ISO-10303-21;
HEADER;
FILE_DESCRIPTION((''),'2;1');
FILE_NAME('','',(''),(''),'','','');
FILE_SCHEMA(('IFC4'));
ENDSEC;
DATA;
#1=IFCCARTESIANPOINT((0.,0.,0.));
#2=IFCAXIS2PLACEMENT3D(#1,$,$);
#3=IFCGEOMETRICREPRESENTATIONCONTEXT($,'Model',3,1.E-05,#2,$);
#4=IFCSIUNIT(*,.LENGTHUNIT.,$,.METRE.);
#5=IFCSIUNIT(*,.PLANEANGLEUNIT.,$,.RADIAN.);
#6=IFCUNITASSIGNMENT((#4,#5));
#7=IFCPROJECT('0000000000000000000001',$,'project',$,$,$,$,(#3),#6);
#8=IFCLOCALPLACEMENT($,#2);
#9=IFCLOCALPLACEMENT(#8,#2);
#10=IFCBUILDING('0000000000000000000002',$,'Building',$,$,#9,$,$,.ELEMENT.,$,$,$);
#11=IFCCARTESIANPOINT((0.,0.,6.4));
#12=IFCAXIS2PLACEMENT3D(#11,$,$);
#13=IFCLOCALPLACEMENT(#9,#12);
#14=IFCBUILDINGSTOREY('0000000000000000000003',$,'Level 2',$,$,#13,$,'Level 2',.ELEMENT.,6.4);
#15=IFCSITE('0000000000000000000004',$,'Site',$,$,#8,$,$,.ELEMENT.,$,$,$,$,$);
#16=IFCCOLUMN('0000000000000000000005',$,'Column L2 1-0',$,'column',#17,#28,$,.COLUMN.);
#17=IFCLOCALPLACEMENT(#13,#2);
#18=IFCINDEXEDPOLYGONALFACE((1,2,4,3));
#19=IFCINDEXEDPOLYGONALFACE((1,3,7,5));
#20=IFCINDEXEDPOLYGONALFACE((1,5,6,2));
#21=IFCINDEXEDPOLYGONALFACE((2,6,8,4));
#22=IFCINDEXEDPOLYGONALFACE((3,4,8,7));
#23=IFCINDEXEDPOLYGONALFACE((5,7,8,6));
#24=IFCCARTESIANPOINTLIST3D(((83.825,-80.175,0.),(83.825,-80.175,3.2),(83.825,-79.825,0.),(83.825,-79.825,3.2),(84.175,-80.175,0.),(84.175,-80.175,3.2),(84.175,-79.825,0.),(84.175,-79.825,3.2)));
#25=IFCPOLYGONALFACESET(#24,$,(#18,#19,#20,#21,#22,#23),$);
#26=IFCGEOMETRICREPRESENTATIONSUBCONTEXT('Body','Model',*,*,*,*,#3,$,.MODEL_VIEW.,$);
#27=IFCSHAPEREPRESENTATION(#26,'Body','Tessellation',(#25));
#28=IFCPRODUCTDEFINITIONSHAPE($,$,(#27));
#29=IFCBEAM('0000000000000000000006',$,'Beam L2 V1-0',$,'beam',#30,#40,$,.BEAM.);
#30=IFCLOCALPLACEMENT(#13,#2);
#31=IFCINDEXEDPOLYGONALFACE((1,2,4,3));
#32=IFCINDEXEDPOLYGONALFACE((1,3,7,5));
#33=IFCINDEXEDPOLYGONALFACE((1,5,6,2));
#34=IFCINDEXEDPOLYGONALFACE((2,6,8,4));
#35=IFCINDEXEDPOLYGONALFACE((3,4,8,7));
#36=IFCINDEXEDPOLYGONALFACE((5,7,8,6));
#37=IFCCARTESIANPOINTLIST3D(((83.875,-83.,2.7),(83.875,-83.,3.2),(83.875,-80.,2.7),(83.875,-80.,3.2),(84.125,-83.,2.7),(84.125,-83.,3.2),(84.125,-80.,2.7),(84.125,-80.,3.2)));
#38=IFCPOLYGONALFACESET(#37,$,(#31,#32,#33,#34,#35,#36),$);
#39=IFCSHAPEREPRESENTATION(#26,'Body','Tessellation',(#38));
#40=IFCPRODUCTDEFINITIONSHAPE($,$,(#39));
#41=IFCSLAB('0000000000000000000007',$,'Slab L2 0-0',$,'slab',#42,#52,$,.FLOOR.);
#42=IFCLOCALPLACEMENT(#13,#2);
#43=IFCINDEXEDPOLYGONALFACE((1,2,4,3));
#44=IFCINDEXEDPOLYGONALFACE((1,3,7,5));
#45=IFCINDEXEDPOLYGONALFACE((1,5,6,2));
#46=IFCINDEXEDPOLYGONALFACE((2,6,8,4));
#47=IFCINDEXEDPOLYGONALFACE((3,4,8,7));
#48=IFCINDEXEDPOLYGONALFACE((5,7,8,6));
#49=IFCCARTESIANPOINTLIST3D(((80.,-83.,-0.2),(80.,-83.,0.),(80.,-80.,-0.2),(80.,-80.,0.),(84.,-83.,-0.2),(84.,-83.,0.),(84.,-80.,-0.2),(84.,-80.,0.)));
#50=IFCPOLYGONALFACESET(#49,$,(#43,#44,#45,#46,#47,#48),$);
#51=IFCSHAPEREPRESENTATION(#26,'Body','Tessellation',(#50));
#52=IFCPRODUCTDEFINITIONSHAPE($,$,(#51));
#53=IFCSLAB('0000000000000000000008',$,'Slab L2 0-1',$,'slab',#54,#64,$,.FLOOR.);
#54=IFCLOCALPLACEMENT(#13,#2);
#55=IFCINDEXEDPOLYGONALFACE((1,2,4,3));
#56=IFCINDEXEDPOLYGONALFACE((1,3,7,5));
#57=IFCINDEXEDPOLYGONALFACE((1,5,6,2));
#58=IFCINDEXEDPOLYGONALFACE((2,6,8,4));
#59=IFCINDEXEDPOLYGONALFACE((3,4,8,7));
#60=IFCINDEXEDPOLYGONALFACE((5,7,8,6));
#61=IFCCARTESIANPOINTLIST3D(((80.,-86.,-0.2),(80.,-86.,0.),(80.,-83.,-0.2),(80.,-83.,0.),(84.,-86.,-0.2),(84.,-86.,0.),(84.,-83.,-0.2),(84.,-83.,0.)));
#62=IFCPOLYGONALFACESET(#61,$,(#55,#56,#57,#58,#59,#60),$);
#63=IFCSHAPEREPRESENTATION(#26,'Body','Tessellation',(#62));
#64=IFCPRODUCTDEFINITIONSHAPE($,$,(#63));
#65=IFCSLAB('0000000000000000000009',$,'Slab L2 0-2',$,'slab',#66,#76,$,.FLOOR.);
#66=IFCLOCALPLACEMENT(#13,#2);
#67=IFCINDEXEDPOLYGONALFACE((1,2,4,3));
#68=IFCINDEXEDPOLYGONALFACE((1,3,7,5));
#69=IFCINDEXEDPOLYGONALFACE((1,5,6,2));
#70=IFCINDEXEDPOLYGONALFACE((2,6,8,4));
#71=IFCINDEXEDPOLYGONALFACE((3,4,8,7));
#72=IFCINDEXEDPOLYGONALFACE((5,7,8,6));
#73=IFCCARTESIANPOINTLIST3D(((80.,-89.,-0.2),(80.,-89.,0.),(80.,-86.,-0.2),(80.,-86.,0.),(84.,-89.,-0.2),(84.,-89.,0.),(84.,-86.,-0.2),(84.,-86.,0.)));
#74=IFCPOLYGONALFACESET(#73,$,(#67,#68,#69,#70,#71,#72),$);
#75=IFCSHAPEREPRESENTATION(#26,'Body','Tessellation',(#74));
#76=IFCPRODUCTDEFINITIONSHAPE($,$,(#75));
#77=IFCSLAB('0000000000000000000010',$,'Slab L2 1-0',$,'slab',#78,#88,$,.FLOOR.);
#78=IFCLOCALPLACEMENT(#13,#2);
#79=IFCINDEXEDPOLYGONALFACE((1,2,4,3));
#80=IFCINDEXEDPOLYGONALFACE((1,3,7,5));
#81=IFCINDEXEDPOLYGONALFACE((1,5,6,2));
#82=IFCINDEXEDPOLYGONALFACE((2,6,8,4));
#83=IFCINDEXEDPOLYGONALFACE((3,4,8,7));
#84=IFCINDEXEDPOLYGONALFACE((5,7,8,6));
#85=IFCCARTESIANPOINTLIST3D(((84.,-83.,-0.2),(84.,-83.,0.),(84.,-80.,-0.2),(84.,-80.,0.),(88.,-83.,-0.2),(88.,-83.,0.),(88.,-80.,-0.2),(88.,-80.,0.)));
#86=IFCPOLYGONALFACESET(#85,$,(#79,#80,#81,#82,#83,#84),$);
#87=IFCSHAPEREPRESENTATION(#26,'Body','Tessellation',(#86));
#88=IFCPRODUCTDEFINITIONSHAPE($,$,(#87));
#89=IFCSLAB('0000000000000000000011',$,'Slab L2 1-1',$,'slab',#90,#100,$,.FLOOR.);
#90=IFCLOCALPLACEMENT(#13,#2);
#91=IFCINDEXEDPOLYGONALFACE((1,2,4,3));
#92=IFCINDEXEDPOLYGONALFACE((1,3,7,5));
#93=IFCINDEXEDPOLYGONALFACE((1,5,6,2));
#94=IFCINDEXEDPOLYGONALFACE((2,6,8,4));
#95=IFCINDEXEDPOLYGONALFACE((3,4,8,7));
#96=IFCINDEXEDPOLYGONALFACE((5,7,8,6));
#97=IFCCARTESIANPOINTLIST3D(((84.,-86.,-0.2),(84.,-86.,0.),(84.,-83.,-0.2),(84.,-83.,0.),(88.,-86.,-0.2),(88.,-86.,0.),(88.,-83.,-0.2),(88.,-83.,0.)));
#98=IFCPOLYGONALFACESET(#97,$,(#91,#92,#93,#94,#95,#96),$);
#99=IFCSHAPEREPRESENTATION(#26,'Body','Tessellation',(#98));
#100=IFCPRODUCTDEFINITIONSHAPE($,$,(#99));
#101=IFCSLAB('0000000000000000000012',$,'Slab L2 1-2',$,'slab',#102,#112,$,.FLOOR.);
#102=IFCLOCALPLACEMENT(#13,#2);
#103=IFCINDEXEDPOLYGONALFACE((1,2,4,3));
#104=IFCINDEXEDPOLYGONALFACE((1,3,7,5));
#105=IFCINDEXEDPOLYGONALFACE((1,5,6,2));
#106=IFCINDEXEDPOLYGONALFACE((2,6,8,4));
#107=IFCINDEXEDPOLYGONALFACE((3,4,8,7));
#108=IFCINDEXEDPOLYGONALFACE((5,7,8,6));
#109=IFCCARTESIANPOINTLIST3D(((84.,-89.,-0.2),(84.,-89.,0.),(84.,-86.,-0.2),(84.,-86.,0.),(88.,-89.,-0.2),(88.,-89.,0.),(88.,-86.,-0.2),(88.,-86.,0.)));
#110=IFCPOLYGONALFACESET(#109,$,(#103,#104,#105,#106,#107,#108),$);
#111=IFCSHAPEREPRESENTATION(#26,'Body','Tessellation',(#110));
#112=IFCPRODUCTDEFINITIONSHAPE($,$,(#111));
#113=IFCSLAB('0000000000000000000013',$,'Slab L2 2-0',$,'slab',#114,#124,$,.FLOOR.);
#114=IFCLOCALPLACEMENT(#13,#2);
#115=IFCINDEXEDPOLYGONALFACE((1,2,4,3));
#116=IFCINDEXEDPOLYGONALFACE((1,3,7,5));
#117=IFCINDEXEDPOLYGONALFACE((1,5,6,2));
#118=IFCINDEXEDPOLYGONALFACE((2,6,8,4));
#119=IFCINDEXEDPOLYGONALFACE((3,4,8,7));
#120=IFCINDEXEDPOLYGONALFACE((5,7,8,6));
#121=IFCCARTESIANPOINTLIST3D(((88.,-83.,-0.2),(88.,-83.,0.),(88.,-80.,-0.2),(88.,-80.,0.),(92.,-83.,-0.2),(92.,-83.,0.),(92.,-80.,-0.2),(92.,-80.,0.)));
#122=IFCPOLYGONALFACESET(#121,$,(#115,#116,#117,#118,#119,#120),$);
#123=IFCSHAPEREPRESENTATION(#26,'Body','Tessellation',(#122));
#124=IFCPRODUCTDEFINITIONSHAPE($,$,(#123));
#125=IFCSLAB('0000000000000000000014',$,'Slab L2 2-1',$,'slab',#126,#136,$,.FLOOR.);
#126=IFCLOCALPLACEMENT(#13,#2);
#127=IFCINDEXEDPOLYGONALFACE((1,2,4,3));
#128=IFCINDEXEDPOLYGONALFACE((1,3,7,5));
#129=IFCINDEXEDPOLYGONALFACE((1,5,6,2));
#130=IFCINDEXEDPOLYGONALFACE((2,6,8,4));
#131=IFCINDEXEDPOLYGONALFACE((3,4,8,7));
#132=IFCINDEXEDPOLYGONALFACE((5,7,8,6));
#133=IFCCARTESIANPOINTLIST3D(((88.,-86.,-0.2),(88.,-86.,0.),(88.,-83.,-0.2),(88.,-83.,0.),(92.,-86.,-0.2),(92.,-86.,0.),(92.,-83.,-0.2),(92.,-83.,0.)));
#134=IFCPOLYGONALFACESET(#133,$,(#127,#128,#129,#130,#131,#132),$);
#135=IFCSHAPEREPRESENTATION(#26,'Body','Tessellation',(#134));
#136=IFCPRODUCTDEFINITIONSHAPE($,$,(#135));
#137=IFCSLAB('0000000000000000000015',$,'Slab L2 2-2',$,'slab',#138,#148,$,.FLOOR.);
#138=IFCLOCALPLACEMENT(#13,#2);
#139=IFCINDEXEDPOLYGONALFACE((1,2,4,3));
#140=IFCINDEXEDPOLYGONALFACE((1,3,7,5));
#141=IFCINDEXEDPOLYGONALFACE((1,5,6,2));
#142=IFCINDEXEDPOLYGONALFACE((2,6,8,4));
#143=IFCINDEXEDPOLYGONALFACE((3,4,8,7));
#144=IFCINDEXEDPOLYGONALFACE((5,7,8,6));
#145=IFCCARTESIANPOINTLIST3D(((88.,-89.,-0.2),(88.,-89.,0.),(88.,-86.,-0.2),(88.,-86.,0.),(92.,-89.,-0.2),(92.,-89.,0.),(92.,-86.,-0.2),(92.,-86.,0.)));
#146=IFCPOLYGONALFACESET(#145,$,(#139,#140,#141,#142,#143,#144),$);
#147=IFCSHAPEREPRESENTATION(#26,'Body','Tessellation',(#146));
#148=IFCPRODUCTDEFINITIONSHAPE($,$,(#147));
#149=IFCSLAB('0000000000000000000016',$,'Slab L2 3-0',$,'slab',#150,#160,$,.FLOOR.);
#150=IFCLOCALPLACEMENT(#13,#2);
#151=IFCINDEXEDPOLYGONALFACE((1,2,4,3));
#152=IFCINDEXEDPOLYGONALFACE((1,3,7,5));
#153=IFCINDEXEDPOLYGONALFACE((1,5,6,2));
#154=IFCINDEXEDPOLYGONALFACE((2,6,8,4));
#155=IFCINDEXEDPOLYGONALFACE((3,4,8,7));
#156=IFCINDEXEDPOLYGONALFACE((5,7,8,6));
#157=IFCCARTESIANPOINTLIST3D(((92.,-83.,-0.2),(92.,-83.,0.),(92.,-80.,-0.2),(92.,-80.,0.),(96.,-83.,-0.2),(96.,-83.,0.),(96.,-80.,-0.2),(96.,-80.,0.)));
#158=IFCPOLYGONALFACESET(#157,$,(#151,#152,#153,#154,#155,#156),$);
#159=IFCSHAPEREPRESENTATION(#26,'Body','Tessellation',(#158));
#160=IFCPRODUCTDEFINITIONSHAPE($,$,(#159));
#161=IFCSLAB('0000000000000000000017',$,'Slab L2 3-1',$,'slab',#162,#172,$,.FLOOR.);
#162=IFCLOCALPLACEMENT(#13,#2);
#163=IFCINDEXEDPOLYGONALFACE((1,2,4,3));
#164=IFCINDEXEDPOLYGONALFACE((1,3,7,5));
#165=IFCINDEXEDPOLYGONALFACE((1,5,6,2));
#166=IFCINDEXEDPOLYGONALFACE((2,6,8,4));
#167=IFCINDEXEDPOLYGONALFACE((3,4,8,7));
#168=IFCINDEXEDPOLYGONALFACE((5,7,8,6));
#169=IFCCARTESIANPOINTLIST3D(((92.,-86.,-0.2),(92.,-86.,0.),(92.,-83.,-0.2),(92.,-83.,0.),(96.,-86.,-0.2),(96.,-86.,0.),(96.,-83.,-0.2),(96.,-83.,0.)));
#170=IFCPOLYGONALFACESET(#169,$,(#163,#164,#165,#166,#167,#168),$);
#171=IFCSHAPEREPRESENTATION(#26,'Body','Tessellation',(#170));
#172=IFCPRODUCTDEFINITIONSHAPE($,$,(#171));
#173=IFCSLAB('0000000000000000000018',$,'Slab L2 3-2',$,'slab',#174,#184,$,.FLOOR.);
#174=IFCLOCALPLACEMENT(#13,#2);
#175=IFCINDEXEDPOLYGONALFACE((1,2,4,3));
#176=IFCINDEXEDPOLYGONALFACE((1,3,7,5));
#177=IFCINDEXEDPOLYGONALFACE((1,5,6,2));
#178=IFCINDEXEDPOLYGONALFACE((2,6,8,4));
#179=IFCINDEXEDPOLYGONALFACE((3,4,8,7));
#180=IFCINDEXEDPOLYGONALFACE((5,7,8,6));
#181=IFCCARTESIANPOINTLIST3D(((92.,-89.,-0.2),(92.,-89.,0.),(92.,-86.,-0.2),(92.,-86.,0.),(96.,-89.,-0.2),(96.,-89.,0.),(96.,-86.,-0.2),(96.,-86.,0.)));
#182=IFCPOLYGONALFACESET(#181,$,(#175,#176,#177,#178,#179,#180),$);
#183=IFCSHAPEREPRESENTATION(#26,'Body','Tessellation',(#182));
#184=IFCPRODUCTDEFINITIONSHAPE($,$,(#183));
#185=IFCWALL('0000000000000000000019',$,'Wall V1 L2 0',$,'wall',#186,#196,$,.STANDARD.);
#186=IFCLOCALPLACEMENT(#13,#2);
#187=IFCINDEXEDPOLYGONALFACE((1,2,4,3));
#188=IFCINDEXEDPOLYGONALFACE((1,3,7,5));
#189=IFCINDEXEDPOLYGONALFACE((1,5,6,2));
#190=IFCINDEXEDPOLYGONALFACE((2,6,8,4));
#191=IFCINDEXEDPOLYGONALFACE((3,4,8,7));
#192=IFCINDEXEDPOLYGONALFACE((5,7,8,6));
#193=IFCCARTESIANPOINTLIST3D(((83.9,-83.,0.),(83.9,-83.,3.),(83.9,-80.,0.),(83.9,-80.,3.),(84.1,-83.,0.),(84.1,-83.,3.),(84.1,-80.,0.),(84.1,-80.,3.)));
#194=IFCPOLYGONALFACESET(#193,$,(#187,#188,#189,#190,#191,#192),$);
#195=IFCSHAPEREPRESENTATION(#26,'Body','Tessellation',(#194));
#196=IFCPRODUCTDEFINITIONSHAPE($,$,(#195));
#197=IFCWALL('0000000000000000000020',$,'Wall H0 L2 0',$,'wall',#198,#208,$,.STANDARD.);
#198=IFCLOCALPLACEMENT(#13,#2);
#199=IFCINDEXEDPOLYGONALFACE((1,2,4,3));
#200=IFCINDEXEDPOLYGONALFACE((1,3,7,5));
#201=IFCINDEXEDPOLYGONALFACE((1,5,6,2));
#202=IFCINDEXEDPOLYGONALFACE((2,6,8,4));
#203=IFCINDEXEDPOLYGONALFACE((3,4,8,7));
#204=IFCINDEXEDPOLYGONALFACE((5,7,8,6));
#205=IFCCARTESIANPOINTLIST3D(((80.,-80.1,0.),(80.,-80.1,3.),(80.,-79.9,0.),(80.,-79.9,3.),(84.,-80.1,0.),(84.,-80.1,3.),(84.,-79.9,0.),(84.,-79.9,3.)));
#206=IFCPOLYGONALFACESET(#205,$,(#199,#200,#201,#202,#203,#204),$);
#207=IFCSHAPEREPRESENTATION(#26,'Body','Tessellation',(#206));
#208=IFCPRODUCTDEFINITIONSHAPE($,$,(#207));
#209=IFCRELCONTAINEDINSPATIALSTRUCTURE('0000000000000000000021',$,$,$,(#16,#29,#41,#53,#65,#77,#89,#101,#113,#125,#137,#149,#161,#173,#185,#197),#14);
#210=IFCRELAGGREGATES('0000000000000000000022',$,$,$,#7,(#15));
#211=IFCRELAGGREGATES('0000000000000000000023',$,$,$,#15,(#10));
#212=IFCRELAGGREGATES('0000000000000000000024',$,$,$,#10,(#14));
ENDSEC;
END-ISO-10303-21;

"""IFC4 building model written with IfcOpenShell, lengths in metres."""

from ifc_helpers import new_model, si_unit, frame, frame_2d, origin, origin_2d, place, context, subcontext, project, spatial, polyline, rectangle, outline, extrude, element, save


model = new_model("IFC4")

# Units and contexts
model_context = context("Model", 3, precision=1e-05, world=origin())
body_context = subcontext(model_context, "Body", "Model", "MODEL_VIEW")
ifc_project = project(units=[si_unit("LENGTHUNIT", "METRE"), si_unit("PLANEANGLEUNIT", "RADIAN")], contexts=[model_context])

# Site, building, storey
site_placement = place(None, origin())
site = spatial("IfcSite", under=ifc_project, at=site_placement, Name="Site", CompositionType="ELEMENT")
building_placement = place(site_placement, origin())
building = spatial("IfcBuilding", under=site, at=building_placement, Name="Building", CompositionType="ELEMENT")
storey_placement = place(building_placement, frame((0.0, 0.0, 6.4)))
storey = spatial("IfcBuildingStorey", under=building, at=storey_placement, Name="Level 2", LongName="Level 2", CompositionType="ELEMENT", Elevation=6.4)

# Column
column_placement = place(storey_placement, frame((84.0, -80.0, 0.0)))
element("IfcColumn", 1, at=column_placement, inside=storey, Name="Column L2 1-0", ObjectType="column", PredefinedType="COLUMN", context=body_context, shape_type="SweptSolid", body=[
    extrude(rectangle(XDim=0.35, YDim=0.35, at=origin_2d()), origin(), (0.0, 0.0, 1.0), 3.2),
])

# Beam
beam_placement = place(storey_placement, frame((84.0, -80.0, 2.95), z_axis=(0.0, -1.0, 0.0), x_axis=(0.0, 0.0, 1.0)))
element("IfcBeam", 2, at=beam_placement, inside=storey, Name="Beam L2 V1-0", ObjectType="beam", PredefinedType="BEAM", context=body_context, shape_type="SweptSolid", body=[
    extrude(rectangle(XDim=0.5, YDim=0.25, at=origin_2d()), origin(), (0.0, 0.0, 1.0), 3.0),
])

# Slabs
slab_1_placement = place(storey_placement, frame((0.0, 0.0, -0.2)))
element("IfcSlab", 3, at=slab_1_placement, inside=storey, Name="Slab L2 0-0", ObjectType="slab", PredefinedType="FLOOR", context=body_context, shape_type="SweptSolid", body=[
    extrude(outline(polyline([(80.0, -83.0), (84.0, -83.0), (84.0, -80.0), (80.0, -80.0), (80.0, -83.0)])), origin(), (0.0, 0.0, 1.0), 0.2),
])
slab_2_placement = place(storey_placement, frame((0.0, 0.0, -0.2)))
element("IfcSlab", 4, at=slab_2_placement, inside=storey, Name="Slab L2 0-1", ObjectType="slab", PredefinedType="FLOOR", context=body_context, shape_type="SweptSolid", body=[
    extrude(outline(polyline([(80.0, -86.0), (84.0, -86.0), (84.0, -83.0), (80.0, -83.0), (80.0, -86.0)])), origin(), (0.0, 0.0, 1.0), 0.2),
])
slab_3_placement = place(storey_placement, frame((0.0, 0.0, -0.2)))
element("IfcSlab", 5, at=slab_3_placement, inside=storey, Name="Slab L2 0-2", ObjectType="slab", PredefinedType="FLOOR", context=body_context, shape_type="SweptSolid", body=[
    extrude(outline(polyline([(80.0, -89.0), (84.0, -89.0), (84.0, -86.0), (80.0, -86.0), (80.0, -89.0)])), origin(), (0.0, 0.0, 1.0), 0.2),
])
slab_4_placement = place(storey_placement, frame((0.0, 0.0, -0.2)))
element("IfcSlab", 6, at=slab_4_placement, inside=storey, Name="Slab L2 1-0", ObjectType="slab", PredefinedType="FLOOR", context=body_context, shape_type="SweptSolid", body=[
    extrude(outline(polyline([(84.0, -83.0), (88.0, -83.0), (88.0, -80.0), (84.0, -80.0), (84.0, -83.0)])), origin(), (0.0, 0.0, 1.0), 0.2),
])
slab_5_placement = place(storey_placement, frame((0.0, 0.0, -0.2)))
element("IfcSlab", 7, at=slab_5_placement, inside=storey, Name="Slab L2 1-1", ObjectType="slab", PredefinedType="FLOOR", context=body_context, shape_type="SweptSolid", body=[
    extrude(outline(polyline([(84.0, -86.0), (88.0, -86.0), (88.0, -83.0), (84.0, -83.0), (84.0, -86.0)])), origin(), (0.0, 0.0, 1.0), 0.2),
])
slab_6_placement = place(storey_placement, frame((0.0, 0.0, -0.2)))
element("IfcSlab", 8, at=slab_6_placement, inside=storey, Name="Slab L2 1-2", ObjectType="slab", PredefinedType="FLOOR", context=body_context, shape_type="SweptSolid", body=[
    extrude(outline(polyline([(84.0, -89.0), (88.0, -89.0), (88.0, -86.0), (84.0, -86.0), (84.0, -89.0)])), origin(), (0.0, 0.0, 1.0), 0.2),
])
slab_7_placement = place(storey_placement, frame((0.0, 0.0, -0.2)))
element("IfcSlab", 9, at=slab_7_placement, inside=storey, Name="Slab L2 2-0", ObjectType="slab", PredefinedType="FLOOR", context=body_context, shape_type="SweptSolid", body=[
    extrude(outline(polyline([(88.0, -83.0), (92.0, -83.0), (92.0, -80.0), (88.0, -80.0), (88.0, -83.0)])), origin(), (0.0, 0.0, 1.0), 0.2),
])
slab_8_placement = place(storey_placement, frame((0.0, 0.0, -0.2)))
element("IfcSlab", 10, at=slab_8_placement, inside=storey, Name="Slab L2 2-1", ObjectType="slab", PredefinedType="FLOOR", context=body_context, shape_type="SweptSolid", body=[
    extrude(outline(polyline([(88.0, -86.0), (92.0, -86.0), (92.0, -83.0), (88.0, -83.0), (88.0, -86.0)])), origin(), (0.0, 0.0, 1.0), 0.2),
])
slab_9_placement = place(storey_placement, frame((0.0, 0.0, -0.2)))
element("IfcSlab", 11, at=slab_9_placement, inside=storey, Name="Slab L2 2-2", ObjectType="slab", PredefinedType="FLOOR", context=body_context, shape_type="SweptSolid", body=[
    extrude(outline(polyline([(88.0, -89.0), (92.0, -89.0), (92.0, -86.0), (88.0, -86.0), (88.0, -89.0)])), origin(), (0.0, 0.0, 1.0), 0.2),
])
slab_10_placement = place(storey_placement, frame((0.0, 0.0, -0.2)))
element("IfcSlab", 12, at=slab_10_placement, inside=storey, Name="Slab L2 3-0", ObjectType="slab", PredefinedType="FLOOR", context=body_context, shape_type="SweptSolid", body=[
    extrude(outline(polyline([(92.0, -83.0), (96.0, -83.0), (96.0, -80.0), (92.0, -80.0), (92.0, -83.0)])), origin(), (0.0, 0.0, 1.0), 0.2),
])
slab_11_placement = place(storey_placement, frame((0.0, 0.0, -0.2)))
element("IfcSlab", 13, at=slab_11_placement, inside=storey, Name="Slab L2 3-1", ObjectType="slab", PredefinedType="FLOOR", context=body_context, shape_type="SweptSolid", body=[
    extrude(outline(polyline([(92.0, -86.0), (96.0, -86.0), (96.0, -83.0), (92.0, -83.0), (92.0, -86.0)])), origin(), (0.0, 0.0, 1.0), 0.2),
])
slab_12_placement = place(storey_placement, frame((0.0, 0.0, -0.2)))
element("IfcSlab", 14, at=slab_12_placement, inside=storey, Name="Slab L2 3-2", ObjectType="slab", PredefinedType="FLOOR", context=body_context, shape_type="SweptSolid", body=[
    extrude(outline(polyline([(92.0, -89.0), (96.0, -89.0), (96.0, -86.0), (92.0, -86.0), (92.0, -89.0)])), origin(), (0.0, 0.0, 1.0), 0.2),
])

# Walls
wall_1_placement = place(storey_placement, frame((84.0, -80.0, 0.0), z_axis=(0.0, 0.0, 1.0), x_axis=(0.0, -1.0, 0.0)))
element("IfcWall", 15, at=wall_1_placement, inside=storey, Name="Wall V1 L2 0", ObjectType="wall", PredefinedType="STANDARD", context=body_context, shape_type="SweptSolid", body=[
    extrude(rectangle(XDim=3.0, YDim=0.2, at=frame_2d((1.5, 0.0))), origin(), (0.0, 0.0, 1.0), 3.0),
])
wall_2_placement = place(storey_placement, frame((80.0, -80.0, 0.0), z_axis=(0.0, 0.0, 1.0), x_axis=(1.0, 0.0, 0.0)))
element("IfcWall", 16, at=wall_2_placement, inside=storey, Name="Wall H0 L2 0", ObjectType="wall", PredefinedType="STANDARD", context=body_context, shape_type="SweptSolid", body=[
    extrude(rectangle(XDim=4.0, YDim=0.2, at=frame_2d((2.0, 0.0))), origin(), (0.0, 0.0, 1.0), 3.0),
])

save(model, "model.ifc")
